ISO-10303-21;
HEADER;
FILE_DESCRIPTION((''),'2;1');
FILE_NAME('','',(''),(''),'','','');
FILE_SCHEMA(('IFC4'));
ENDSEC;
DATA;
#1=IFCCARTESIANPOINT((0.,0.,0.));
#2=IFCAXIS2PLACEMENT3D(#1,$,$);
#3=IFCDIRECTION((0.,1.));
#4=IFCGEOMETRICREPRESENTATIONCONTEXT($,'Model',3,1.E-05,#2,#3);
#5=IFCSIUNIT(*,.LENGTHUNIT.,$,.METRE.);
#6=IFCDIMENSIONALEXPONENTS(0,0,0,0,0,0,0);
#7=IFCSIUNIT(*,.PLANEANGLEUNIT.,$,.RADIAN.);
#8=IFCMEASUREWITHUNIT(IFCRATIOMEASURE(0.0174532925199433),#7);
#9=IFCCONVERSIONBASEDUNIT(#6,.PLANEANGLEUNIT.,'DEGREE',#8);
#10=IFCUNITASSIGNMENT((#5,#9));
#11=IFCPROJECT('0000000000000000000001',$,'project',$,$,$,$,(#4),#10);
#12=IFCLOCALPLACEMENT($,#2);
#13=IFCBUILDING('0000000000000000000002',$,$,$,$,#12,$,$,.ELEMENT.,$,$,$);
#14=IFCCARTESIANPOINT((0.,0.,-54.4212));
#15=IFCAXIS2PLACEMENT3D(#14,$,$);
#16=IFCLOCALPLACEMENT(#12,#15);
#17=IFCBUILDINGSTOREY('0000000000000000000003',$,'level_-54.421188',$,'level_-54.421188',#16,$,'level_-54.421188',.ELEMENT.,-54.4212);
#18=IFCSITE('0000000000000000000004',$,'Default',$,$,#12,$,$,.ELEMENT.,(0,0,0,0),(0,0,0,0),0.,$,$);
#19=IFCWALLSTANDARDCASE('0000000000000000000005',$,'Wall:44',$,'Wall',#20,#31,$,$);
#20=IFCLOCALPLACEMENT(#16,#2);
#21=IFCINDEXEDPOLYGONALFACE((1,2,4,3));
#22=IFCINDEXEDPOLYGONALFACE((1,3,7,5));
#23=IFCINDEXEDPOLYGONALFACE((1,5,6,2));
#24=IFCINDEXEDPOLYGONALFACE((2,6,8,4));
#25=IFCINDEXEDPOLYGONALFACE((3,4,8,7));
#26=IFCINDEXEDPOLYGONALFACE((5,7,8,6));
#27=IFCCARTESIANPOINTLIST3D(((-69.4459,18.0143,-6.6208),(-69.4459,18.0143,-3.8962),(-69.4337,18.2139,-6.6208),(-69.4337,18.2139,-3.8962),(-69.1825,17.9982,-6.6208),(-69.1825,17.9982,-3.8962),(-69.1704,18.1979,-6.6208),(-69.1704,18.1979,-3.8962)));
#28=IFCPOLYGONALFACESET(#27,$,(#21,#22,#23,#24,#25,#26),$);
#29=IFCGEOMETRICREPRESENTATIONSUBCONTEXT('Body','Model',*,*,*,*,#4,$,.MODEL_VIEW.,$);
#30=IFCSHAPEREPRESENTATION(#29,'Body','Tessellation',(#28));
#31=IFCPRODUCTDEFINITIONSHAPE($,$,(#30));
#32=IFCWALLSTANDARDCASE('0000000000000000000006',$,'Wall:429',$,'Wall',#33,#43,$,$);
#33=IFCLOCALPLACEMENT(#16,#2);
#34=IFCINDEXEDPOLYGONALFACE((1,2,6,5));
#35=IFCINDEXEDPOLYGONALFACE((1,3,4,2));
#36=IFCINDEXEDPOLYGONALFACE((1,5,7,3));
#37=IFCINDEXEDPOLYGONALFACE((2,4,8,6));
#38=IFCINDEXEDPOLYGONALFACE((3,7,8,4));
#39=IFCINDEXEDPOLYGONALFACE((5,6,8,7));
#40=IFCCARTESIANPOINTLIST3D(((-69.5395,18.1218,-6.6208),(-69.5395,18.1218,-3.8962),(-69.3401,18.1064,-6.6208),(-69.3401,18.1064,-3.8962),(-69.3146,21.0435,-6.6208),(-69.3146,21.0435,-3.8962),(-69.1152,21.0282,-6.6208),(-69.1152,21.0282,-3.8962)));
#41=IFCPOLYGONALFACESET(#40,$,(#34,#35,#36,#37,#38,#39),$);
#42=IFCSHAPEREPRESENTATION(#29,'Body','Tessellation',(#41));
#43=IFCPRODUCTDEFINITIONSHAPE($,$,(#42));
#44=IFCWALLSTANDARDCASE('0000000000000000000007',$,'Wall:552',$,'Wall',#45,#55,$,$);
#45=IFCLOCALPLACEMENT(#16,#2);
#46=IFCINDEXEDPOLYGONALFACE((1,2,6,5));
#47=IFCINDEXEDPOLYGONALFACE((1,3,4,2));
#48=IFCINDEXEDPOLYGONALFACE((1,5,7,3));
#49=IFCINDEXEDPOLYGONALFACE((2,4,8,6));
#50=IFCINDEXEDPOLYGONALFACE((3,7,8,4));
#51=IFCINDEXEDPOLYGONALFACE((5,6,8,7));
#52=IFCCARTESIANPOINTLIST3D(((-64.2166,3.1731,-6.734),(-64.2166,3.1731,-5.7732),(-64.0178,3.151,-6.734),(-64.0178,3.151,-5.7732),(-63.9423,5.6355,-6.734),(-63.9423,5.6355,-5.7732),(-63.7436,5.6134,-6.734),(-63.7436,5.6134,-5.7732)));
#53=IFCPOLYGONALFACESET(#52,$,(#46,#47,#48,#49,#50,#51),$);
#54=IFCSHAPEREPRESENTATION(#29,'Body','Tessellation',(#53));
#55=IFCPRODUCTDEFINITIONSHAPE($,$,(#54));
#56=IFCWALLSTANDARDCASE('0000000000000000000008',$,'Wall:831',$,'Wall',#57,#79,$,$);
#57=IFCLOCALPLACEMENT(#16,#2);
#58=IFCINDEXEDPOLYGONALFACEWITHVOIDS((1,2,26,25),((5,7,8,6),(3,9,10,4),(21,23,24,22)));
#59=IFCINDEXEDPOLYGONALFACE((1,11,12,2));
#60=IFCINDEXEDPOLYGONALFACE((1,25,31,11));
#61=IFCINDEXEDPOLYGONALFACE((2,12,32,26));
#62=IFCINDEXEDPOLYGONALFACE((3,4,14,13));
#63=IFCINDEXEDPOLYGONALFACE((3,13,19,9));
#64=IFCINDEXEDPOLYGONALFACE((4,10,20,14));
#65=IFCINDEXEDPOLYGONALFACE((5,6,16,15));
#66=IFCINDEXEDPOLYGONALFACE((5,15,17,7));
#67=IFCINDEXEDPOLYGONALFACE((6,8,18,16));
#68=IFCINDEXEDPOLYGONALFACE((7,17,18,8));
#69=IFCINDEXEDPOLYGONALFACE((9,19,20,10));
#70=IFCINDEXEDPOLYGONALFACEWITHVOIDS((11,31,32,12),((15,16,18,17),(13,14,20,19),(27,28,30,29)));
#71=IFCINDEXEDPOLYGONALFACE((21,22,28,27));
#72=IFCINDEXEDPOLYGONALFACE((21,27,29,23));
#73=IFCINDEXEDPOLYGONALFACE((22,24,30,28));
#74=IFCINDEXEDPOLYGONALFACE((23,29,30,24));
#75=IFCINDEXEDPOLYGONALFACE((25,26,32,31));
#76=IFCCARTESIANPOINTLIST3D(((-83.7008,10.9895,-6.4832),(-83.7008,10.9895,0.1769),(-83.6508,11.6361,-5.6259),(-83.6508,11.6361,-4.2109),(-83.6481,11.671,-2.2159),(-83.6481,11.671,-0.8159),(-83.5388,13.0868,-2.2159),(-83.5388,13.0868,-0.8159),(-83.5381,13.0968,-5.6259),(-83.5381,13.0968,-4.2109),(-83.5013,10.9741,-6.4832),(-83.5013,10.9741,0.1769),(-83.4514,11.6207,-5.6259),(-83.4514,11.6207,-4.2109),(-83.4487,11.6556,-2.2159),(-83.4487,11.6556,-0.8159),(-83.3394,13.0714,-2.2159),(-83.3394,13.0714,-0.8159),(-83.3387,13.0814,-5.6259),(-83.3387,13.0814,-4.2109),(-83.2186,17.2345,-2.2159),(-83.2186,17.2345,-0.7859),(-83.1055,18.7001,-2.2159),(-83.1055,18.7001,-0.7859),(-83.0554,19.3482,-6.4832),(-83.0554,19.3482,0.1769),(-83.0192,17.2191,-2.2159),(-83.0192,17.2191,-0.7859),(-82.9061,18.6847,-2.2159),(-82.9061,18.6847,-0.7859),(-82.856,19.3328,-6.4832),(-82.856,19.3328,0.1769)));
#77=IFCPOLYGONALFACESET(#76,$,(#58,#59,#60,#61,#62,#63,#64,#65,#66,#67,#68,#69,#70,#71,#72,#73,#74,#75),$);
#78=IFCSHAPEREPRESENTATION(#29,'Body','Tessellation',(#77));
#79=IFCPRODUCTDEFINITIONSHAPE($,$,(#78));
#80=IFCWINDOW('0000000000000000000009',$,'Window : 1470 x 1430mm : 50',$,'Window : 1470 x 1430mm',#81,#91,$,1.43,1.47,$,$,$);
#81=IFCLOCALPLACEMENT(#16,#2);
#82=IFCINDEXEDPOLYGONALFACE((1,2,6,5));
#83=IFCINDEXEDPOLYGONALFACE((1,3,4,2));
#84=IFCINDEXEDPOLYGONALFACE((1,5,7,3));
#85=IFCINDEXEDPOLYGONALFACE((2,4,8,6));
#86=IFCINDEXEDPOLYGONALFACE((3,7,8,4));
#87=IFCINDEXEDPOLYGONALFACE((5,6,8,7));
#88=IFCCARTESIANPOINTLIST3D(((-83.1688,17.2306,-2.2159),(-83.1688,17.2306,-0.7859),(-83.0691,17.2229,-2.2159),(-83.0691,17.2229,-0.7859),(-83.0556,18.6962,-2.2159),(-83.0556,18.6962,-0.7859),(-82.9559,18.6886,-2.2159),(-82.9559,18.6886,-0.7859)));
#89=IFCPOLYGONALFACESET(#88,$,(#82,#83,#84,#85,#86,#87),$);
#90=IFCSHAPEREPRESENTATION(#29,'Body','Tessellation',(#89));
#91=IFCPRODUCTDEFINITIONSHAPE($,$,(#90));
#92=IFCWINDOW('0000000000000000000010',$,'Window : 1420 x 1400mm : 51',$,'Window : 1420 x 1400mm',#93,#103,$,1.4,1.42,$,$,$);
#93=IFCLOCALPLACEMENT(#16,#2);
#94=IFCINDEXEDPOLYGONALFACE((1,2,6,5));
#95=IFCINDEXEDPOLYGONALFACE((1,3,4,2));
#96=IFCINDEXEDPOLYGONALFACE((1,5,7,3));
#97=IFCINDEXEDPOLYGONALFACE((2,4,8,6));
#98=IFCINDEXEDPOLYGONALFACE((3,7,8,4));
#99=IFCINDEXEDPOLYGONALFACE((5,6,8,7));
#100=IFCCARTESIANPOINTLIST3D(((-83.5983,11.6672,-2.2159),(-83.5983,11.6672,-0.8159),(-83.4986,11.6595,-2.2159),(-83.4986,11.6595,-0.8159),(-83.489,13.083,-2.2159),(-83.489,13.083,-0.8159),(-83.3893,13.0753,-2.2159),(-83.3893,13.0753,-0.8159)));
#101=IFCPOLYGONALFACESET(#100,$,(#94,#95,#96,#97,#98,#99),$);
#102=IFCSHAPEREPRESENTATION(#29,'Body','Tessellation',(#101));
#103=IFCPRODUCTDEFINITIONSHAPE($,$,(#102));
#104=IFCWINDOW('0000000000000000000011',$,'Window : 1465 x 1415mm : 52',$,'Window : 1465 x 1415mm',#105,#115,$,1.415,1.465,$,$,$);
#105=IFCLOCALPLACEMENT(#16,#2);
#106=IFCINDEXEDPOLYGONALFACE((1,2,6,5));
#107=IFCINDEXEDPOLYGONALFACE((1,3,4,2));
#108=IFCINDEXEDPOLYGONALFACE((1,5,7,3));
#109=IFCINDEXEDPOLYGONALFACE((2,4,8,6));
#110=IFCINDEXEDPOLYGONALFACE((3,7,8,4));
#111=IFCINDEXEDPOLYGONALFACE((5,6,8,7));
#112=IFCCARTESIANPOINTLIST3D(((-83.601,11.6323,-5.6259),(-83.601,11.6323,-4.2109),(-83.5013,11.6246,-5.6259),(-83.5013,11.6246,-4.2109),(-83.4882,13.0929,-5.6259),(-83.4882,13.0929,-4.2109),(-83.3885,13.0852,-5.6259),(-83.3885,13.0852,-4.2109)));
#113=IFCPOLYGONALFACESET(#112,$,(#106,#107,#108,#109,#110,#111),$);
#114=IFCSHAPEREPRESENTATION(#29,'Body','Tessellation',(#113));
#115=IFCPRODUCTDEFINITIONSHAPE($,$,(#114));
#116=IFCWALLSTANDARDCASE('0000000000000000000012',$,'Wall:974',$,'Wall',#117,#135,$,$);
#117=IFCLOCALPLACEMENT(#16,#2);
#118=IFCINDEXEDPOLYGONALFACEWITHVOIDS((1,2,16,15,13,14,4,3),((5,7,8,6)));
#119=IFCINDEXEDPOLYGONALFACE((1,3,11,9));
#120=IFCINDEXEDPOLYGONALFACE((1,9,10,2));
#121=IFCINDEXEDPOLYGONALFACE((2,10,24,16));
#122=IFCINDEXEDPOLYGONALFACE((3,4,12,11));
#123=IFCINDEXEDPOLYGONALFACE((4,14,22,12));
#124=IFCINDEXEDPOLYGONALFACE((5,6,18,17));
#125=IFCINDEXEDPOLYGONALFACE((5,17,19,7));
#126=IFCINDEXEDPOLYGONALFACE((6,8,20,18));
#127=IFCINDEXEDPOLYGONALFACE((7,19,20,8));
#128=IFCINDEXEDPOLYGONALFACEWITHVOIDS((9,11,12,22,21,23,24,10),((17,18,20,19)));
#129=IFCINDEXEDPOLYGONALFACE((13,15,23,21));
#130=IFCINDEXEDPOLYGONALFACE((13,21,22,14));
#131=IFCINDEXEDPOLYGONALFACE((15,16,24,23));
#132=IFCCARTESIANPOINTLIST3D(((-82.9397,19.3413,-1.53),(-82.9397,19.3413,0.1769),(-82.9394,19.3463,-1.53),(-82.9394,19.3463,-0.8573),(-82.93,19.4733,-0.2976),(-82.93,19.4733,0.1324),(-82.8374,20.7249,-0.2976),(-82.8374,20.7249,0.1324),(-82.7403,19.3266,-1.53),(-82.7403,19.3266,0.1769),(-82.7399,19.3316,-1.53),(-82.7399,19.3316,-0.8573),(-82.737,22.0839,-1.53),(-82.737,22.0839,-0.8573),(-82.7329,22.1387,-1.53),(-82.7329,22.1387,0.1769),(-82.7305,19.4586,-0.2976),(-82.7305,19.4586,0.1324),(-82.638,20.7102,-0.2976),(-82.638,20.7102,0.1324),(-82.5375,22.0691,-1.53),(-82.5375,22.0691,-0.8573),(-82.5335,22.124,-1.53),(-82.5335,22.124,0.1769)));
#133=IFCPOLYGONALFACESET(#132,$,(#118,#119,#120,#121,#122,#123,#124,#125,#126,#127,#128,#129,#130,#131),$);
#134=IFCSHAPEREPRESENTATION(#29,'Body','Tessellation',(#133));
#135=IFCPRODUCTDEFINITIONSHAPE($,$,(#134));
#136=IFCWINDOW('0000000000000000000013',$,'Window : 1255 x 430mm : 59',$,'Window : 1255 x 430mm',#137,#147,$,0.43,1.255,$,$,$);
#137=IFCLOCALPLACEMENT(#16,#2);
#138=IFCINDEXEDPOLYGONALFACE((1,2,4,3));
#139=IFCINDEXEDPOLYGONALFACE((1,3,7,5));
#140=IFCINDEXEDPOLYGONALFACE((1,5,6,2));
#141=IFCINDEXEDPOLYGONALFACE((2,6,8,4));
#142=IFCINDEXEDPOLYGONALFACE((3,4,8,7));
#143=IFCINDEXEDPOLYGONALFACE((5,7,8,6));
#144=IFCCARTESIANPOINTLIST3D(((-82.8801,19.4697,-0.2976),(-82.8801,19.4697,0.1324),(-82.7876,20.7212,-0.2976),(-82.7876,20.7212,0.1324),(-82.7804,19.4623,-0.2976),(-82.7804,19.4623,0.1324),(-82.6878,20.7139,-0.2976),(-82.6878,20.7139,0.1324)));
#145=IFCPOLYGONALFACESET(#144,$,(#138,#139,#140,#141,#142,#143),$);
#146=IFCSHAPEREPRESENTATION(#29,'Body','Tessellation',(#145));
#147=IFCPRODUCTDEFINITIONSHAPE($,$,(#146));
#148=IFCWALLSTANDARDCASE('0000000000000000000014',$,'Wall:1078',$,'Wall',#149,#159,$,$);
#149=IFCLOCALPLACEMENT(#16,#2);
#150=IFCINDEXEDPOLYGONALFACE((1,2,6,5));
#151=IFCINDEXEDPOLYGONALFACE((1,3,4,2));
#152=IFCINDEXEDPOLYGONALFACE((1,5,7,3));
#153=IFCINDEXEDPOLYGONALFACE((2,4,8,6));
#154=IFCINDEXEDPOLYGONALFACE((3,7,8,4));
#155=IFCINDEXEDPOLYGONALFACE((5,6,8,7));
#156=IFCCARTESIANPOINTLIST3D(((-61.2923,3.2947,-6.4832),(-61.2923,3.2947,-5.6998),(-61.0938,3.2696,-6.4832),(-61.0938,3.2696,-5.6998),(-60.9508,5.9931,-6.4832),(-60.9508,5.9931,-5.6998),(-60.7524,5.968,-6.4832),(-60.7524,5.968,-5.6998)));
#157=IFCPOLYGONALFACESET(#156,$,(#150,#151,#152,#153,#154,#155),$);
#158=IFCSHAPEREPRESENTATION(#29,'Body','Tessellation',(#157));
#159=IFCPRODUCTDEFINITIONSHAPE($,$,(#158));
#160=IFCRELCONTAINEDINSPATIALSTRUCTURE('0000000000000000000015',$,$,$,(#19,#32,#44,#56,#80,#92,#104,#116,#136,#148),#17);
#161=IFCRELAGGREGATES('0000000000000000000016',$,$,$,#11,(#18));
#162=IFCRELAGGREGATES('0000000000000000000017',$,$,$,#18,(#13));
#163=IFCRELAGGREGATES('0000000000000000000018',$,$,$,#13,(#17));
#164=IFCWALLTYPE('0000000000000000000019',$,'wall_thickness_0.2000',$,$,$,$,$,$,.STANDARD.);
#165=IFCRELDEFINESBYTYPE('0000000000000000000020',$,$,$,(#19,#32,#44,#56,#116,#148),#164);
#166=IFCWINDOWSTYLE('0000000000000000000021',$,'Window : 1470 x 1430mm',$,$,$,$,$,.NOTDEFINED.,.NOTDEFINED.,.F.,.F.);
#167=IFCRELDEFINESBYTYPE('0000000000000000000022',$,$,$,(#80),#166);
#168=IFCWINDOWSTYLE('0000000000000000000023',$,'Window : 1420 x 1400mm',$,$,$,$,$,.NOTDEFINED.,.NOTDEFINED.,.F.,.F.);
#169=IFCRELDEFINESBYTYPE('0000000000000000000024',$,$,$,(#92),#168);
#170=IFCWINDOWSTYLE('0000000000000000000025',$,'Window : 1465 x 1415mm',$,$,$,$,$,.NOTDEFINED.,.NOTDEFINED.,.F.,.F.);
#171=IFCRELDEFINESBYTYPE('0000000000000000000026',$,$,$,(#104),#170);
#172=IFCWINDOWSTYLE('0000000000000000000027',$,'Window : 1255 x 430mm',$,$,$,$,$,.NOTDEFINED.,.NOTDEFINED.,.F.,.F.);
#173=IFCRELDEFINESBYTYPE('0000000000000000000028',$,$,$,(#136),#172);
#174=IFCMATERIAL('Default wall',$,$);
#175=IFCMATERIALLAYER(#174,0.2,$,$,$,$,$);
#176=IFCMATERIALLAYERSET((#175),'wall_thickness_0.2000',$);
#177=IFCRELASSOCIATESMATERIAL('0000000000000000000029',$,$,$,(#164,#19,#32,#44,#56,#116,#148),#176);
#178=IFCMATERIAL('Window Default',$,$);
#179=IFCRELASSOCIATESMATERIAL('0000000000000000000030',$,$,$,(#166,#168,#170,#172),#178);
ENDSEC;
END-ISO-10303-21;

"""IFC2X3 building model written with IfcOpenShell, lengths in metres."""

from ifc_helpers import new_model, entity, si_unit, converted_unit, direction, frame, frame_2d, origin, origin_2d_with_axis, place, context, subcontext, project, spatial, polyline, rectangle, outline, extrude, source, transform, mapped, material, layer, layer_set, layer_usage, type_object, type_shapes, element, fill, save


model = new_model("IFC2X3")

# Units and contexts
model_context = context("Model", 3, precision=1e-05, world=origin(), true_north=direction((0.0, 1.0)))
body_context = subcontext(model_context, "Body", "Model", "MODEL_VIEW")
ifc_project = project(units=[si_unit("LENGTHUNIT", "METRE"), converted_unit("PLANEANGLEUNIT", "DEGREE", entity("IfcRatioMeasure", 0.0174532925199433), si_unit("PLANEANGLEUNIT", "RADIAN"), dimensions=[0, 0, 0, 0, 0, 0, 0])], contexts=[model_context])

# Site, building, storey
placement_1 = place(None, origin())
site = spatial("IfcSite", under=ifc_project, at=placement_1, Name="Default", CompositionType="ELEMENT", RefLatitude=(0, 0, 0, 0), RefLongitude=(0, 0, 0, 0), RefElevation=0.0)
building = spatial("IfcBuilding", under=site, at=placement_1, CompositionType="ELEMENT")
storey_placement = place(placement_1, frame((0.0, 0.0, -54.4212)))
storey = spatial("IfcBuildingStorey", under=building, at=storey_placement, Name="level_-54.421188", ObjectType="level_-54.421188", LongName="level_-54.421188", CompositionType="ELEMENT", Elevation=-54.4212)

# Walls
ifc_material_1 = material(Name="Default wall")
ifc_layer = layer(ifc_material_1, 0.2)
ifc_layer_set = layer_set([ifc_layer], Name="wall_thickness_0.2000")
ifc_layer_usage = layer_usage(ifc_layer_set, "AXIS2", "POSITIVE", -0.1)
wall_type = type_object("IfcWallType", Name="wall_thickness_0.2000", PredefinedType="STANDARD", material=ifc_layer_set)
placement_2 = place(placement_1, frame((0.0, 0.0, -61.042)))
wall_1_placement = place(placement_2, frame((-69.1765, 18.0981, 0.0), z_axis=(0.0, 0.0, 1.0), x_axis=(-0.998144, 0.060898, 0.0)))
element("IfcWallStandardCase", 1, at=wall_1_placement, inside=storey, type_object=wall_type, material=ifc_layer_usage, Name="Wall:44", ObjectType="Wall", context=body_context, shape_type="SweptSolid", body=[
    extrude(outline(polyline([(0.2638, -0.1), (0.2638, 0.1), (0.0, 0.1), (0.0, -0.1), (0.2638, -0.1)])), origin(), (0.0, 0.0, 1.0), 2.7247),
])
placement_3 = place(placement_1, frame((0.0, 0.0, -61.042)))
wall_2_placement = place(placement_3, frame((-69.2149, 21.0358, 0.0), z_axis=(0.0, 0.0, 1.0), x_axis=(-0.076735, -0.997052, 0.0)))
element("IfcWallStandardCase", 2, at=wall_2_placement, inside=storey, type_object=wall_type, material=ifc_layer_usage, Name="Wall:429", ObjectType="Wall", context=body_context, shape_type="SweptSolid", body=[
    extrude(outline(polyline([(2.9304, -0.1), (2.9304, 0.1), (0.0, 0.1), (0.0, -0.1), (2.9304, -0.1)])), origin(), (0.0, 0.0, 1.0), 2.7247),
])
placement_4 = place(placement_1, frame((0.0, 0.0, -61.1552)))
wall_3_placement = place(placement_4, frame((-64.1172, 3.1621, 0.0), z_axis=(0.0, 0.0, 1.0), x_axis=(0.110682, 0.993856, 0.0)))
element("IfcWallStandardCase", 3, at=wall_3_placement, inside=storey, type_object=wall_type, material=ifc_layer_usage, Name="Wall:552", ObjectType="Wall", context=body_context, shape_type="SweptSolid", body=[
    extrude(outline(polyline([(2.4776, -0.1), (2.4776, 0.1), (0.0, 0.1), (0.0, -0.1), (2.4776, -0.1)])), origin(), (0.0, 0.0, 1.0), 0.9608),
])

# Wall, openings, windows
placement_5 = place(placement_1, frame((0.0, 0.0, -60.9044)))
wall_4_placement = place(placement_5, frame((-82.9557, 19.3405, 0.0), z_axis=(0.0, 0.0, 1.0), x_axis=(-0.076975, -0.997033, 0.0)))
wall_4 = element("IfcWallStandardCase", 4, at=wall_4_placement, inside=storey, type_object=wall_type, material=ifc_layer_usage, Name="Wall:831", ObjectType="Wall", context=body_context, shape_type="SweptSolid", body=[
    extrude(outline(polyline([(8.3835, -0.1), (8.3835, 0.1), (0.0, 0.1), (0.0, -0.1), (8.3835, -0.1)])), origin(), (0.0, 0.0, 1.0), 6.6601),
])
opening_1_placement = place(wall_4_placement, frame((0.65, -0.1, 4.2674)))
opening_1 = element("IfcOpeningElement", 5, at=opening_1_placement, cuts=wall_4, ObjectType="Opening", context=body_context, shape_type="SweptSolid", body=[
    extrude(rectangle(XDim=1.47, YDim=1.43, at=frame_2d((0.715, 0.735), x_axis=(0.0, 1.0))), frame((0.0, 0.0, 0.0), z_axis=(0.0, 1.0, 0.0), x_axis=(0.0, 0.0, 1.0)), (0.0, 0.0, 1.0), 0.2),
])
opening_2_placement = place(wall_4_placement, frame((6.28, -0.1, 4.2674)))
opening_2 = element("IfcOpeningElement", 6, at=opening_2_placement, cuts=wall_4, ObjectType="Opening", context=body_context, shape_type="SweptSolid", body=[
    extrude(rectangle(XDim=1.42, YDim=1.4, at=frame_2d((0.7, 0.71), x_axis=(0.0, 1.0))), frame((0.0, 0.0, 0.0), z_axis=(0.0, 1.0, 0.0), x_axis=(0.0, 0.0, 1.0)), (0.0, 0.0, 1.0), 0.2),
])
opening_3_placement = place(wall_4_placement, frame((6.27, -0.1, 0.8574)))
opening_3 = element("IfcOpeningElement", 7, at=opening_3_placement, cuts=wall_4, ObjectType="Opening", context=body_context, shape_type="SweptSolid", body=[
    extrude(rectangle(XDim=1.465, YDim=1.415, at=frame_2d((0.7075, 0.7325), x_axis=(0.0, 1.0))), frame((0.0, 0.0, 0.0), z_axis=(0.0, 1.0, 0.0), x_axis=(0.0, 0.0, 1.0)), (0.0, 0.0, 1.0), 0.2),
])
ifc_material_2 = material(Name="Window Default")
window_style_1 = type_object("IfcWindowStyle", Name="Window : 1470 x 1430mm", ConstructionType="NOTDEFINED", OperationType="NOTDEFINED", ParameterTakesPrecedence=False, Sizeable=False, material=ifc_material_2)
shared_shape_1 = source(origin(), body_context, "Body", "SweptSolid", [
    extrude(rectangle(XDim=0.1, YDim=1.47, at=origin_2d_with_axis()), frame((0.735, 0.1, 0.0), z_axis=(0.0, 0.0, 1.0), x_axis=(0.0, 1.0, 0.0)), (0.0, 0.0, 1.0), 1.43),
])
type_shapes(window_style_1, [shared_shape_1])
window_1_placement = place(opening_1_placement, origin())
window_1 = element("IfcWindow", 8, at=window_1_placement, inside=storey, type_object=window_style_1, Name="Window : 1470 x 1430mm : 50", ObjectType="Window : 1470 x 1430mm", OverallHeight=1.43, OverallWidth=1.47, context=body_context, shape_type="MappedRepresentation", body=[
    mapped(shared_shape_1, transform((0.0, 0.0, 0.0), scale=1.0)),
])
fill(opening_1, window_1)
window_style_2 = type_object("IfcWindowStyle", Name="Window : 1420 x 1400mm", ConstructionType="NOTDEFINED", OperationType="NOTDEFINED", ParameterTakesPrecedence=False, Sizeable=False, material=ifc_material_2)
shared_shape_2 = source(origin(), body_context, "Body", "SweptSolid", [
    extrude(rectangle(XDim=0.1, YDim=1.42, at=origin_2d_with_axis()), frame((0.71, 0.1, 0.0), z_axis=(0.0, 0.0, 1.0), x_axis=(0.0, 1.0, 0.0)), (0.0, 0.0, 1.0), 1.4),
])
type_shapes(window_style_2, [shared_shape_2])
window_2_placement = place(opening_2_placement, origin())
window_2 = element("IfcWindow", 9, at=window_2_placement, inside=storey, type_object=window_style_2, Name="Window : 1420 x 1400mm : 51", ObjectType="Window : 1420 x 1400mm", OverallHeight=1.4, OverallWidth=1.42, context=body_context, shape_type="MappedRepresentation", body=[
    mapped(shared_shape_2, transform((0.0, 0.0, 0.0), scale=1.0)),
])
fill(opening_2, window_2)
window_style_3 = type_object("IfcWindowStyle", Name="Window : 1465 x 1415mm", ConstructionType="NOTDEFINED", OperationType="NOTDEFINED", ParameterTakesPrecedence=False, Sizeable=False, material=ifc_material_2)
shared_shape_3 = source(origin(), body_context, "Body", "SweptSolid", [
    extrude(rectangle(XDim=0.1, YDim=1.465, at=origin_2d_with_axis()), frame((0.7325, 0.1, 0.0), z_axis=(0.0, 0.0, 1.0), x_axis=(0.0, 1.0, 0.0)), (0.0, 0.0, 1.0), 1.415),
])
type_shapes(window_style_3, [shared_shape_3])
window_3_placement = place(opening_3_placement, origin())
window_3 = element("IfcWindow", 10, at=window_3_placement, inside=storey, type_object=window_style_3, Name="Window : 1465 x 1415mm : 52", ObjectType="Window : 1465 x 1415mm", OverallHeight=1.415, OverallWidth=1.465, context=body_context, shape_type="MappedRepresentation", body=[
    mapped(shared_shape_3, transform((0.0, 0.0, 0.0), scale=1.0)),
])
fill(opening_3, window_3)

# Wall, openings, window
placement_6 = place(placement_1, frame((0.0, 0.0, -55.9512)))
wall_5_placement = place(placement_6, frame((-82.6332, 22.1313, 0.0), z_axis=(0.0, 0.0, 1.0), x_axis=(-0.073724, -0.997279, 0.0)))
wall_5 = element("IfcWallStandardCase", 11, at=wall_5_placement, inside=storey, type_object=wall_type, material=ifc_layer_usage, Name="Wall:974", ObjectType="Wall", context=body_context, shape_type="SweptSolid", body=[
    extrude(outline(polyline([(2.805, -0.1), (2.805, 0.1), (0.0, 0.1), (0.0, -0.1), (2.805, -0.1)])), origin(), (0.0, 0.0, 1.0), 1.7069),
])
opening_4_placement = place(wall_5_placement, frame((0.055, -0.1, -1.8623)))
element("IfcOpeningElement", 12, at=opening_4_placement, cuts=wall_5, ObjectType="Opening", context=body_context, shape_type="SweptSolid", body=[
    extrude(rectangle(XDim=2.745, YDim=2.535, at=frame_2d((1.2675, 1.3725), x_axis=(0.0, 1.0))), frame((0.0, 0.0, 0.0), z_axis=(0.0, 1.0, 0.0), x_axis=(0.0, 0.0, 1.0)), (0.0, 0.0, 1.0), 0.2),
])
opening_5_placement = place(wall_5_placement, frame((1.4176, -0.1, 1.2323)))
opening_5 = element("IfcOpeningElement", 13, at=opening_5_placement, cuts=wall_5, ObjectType="Opening", context=body_context, shape_type="SweptSolid", body=[
    extrude(rectangle(XDim=1.255, YDim=0.43, at=frame_2d((0.215, 0.6275), x_axis=(0.0, 1.0))), frame((0.0, 0.0, 0.0), z_axis=(0.0, 1.0, 0.0), x_axis=(0.0, 0.0, 1.0)), (0.0, 0.0, 1.0), 0.2),
])
window_style_4 = type_object("IfcWindowStyle", Name="Window : 1255 x 430mm", ConstructionType="NOTDEFINED", OperationType="NOTDEFINED", ParameterTakesPrecedence=False, Sizeable=False, material=ifc_material_2)
shared_shape_4 = source(origin(), body_context, "Body", "SweptSolid", [
    extrude(rectangle(XDim=0.1, YDim=1.255, at=origin_2d_with_axis()), frame((0.6275, 0.1, 0.0), z_axis=(0.0, 0.0, 1.0), x_axis=(0.0, 1.0, 0.0)), (0.0, 0.0, 1.0), 0.43),
])
type_shapes(window_style_4, [shared_shape_4])
window_4_placement = place(opening_5_placement, origin())
window_4 = element("IfcWindow", 14, at=window_4_placement, inside=storey, type_object=window_style_4, Name="Window : 1255 x 430mm : 59", ObjectType="Window : 1255 x 430mm", OverallHeight=0.43, OverallWidth=1.255, context=body_context, shape_type="MappedRepresentation", body=[
    mapped(shared_shape_4, transform((0.0, 0.0, 0.0), scale=1.0)),
])
fill(opening_5, window_4)

# Wall
placement_7 = place(placement_1, frame((0.0, 0.0, -60.9044)))
wall_6_placement = place(placement_7, frame((-61.1931, 3.2821, 0.0), z_axis=(0.0, 0.0, 1.0), x_axis=(0.125529, 0.99209, 0.0)))
element("IfcWallStandardCase", 15, at=wall_6_placement, inside=storey, type_object=wall_type, material=ifc_layer_usage, Name="Wall:1078", ObjectType="Wall", context=body_context, shape_type="SweptSolid", body=[
    extrude(outline(polyline([(2.72, -0.1), (2.72, 0.1), (0.0, 0.1), (0.0, -0.1), (2.72, -0.1)])), origin(), (0.0, 0.0, 1.0), 0.7835),
])

save(model, "model.ifc")
